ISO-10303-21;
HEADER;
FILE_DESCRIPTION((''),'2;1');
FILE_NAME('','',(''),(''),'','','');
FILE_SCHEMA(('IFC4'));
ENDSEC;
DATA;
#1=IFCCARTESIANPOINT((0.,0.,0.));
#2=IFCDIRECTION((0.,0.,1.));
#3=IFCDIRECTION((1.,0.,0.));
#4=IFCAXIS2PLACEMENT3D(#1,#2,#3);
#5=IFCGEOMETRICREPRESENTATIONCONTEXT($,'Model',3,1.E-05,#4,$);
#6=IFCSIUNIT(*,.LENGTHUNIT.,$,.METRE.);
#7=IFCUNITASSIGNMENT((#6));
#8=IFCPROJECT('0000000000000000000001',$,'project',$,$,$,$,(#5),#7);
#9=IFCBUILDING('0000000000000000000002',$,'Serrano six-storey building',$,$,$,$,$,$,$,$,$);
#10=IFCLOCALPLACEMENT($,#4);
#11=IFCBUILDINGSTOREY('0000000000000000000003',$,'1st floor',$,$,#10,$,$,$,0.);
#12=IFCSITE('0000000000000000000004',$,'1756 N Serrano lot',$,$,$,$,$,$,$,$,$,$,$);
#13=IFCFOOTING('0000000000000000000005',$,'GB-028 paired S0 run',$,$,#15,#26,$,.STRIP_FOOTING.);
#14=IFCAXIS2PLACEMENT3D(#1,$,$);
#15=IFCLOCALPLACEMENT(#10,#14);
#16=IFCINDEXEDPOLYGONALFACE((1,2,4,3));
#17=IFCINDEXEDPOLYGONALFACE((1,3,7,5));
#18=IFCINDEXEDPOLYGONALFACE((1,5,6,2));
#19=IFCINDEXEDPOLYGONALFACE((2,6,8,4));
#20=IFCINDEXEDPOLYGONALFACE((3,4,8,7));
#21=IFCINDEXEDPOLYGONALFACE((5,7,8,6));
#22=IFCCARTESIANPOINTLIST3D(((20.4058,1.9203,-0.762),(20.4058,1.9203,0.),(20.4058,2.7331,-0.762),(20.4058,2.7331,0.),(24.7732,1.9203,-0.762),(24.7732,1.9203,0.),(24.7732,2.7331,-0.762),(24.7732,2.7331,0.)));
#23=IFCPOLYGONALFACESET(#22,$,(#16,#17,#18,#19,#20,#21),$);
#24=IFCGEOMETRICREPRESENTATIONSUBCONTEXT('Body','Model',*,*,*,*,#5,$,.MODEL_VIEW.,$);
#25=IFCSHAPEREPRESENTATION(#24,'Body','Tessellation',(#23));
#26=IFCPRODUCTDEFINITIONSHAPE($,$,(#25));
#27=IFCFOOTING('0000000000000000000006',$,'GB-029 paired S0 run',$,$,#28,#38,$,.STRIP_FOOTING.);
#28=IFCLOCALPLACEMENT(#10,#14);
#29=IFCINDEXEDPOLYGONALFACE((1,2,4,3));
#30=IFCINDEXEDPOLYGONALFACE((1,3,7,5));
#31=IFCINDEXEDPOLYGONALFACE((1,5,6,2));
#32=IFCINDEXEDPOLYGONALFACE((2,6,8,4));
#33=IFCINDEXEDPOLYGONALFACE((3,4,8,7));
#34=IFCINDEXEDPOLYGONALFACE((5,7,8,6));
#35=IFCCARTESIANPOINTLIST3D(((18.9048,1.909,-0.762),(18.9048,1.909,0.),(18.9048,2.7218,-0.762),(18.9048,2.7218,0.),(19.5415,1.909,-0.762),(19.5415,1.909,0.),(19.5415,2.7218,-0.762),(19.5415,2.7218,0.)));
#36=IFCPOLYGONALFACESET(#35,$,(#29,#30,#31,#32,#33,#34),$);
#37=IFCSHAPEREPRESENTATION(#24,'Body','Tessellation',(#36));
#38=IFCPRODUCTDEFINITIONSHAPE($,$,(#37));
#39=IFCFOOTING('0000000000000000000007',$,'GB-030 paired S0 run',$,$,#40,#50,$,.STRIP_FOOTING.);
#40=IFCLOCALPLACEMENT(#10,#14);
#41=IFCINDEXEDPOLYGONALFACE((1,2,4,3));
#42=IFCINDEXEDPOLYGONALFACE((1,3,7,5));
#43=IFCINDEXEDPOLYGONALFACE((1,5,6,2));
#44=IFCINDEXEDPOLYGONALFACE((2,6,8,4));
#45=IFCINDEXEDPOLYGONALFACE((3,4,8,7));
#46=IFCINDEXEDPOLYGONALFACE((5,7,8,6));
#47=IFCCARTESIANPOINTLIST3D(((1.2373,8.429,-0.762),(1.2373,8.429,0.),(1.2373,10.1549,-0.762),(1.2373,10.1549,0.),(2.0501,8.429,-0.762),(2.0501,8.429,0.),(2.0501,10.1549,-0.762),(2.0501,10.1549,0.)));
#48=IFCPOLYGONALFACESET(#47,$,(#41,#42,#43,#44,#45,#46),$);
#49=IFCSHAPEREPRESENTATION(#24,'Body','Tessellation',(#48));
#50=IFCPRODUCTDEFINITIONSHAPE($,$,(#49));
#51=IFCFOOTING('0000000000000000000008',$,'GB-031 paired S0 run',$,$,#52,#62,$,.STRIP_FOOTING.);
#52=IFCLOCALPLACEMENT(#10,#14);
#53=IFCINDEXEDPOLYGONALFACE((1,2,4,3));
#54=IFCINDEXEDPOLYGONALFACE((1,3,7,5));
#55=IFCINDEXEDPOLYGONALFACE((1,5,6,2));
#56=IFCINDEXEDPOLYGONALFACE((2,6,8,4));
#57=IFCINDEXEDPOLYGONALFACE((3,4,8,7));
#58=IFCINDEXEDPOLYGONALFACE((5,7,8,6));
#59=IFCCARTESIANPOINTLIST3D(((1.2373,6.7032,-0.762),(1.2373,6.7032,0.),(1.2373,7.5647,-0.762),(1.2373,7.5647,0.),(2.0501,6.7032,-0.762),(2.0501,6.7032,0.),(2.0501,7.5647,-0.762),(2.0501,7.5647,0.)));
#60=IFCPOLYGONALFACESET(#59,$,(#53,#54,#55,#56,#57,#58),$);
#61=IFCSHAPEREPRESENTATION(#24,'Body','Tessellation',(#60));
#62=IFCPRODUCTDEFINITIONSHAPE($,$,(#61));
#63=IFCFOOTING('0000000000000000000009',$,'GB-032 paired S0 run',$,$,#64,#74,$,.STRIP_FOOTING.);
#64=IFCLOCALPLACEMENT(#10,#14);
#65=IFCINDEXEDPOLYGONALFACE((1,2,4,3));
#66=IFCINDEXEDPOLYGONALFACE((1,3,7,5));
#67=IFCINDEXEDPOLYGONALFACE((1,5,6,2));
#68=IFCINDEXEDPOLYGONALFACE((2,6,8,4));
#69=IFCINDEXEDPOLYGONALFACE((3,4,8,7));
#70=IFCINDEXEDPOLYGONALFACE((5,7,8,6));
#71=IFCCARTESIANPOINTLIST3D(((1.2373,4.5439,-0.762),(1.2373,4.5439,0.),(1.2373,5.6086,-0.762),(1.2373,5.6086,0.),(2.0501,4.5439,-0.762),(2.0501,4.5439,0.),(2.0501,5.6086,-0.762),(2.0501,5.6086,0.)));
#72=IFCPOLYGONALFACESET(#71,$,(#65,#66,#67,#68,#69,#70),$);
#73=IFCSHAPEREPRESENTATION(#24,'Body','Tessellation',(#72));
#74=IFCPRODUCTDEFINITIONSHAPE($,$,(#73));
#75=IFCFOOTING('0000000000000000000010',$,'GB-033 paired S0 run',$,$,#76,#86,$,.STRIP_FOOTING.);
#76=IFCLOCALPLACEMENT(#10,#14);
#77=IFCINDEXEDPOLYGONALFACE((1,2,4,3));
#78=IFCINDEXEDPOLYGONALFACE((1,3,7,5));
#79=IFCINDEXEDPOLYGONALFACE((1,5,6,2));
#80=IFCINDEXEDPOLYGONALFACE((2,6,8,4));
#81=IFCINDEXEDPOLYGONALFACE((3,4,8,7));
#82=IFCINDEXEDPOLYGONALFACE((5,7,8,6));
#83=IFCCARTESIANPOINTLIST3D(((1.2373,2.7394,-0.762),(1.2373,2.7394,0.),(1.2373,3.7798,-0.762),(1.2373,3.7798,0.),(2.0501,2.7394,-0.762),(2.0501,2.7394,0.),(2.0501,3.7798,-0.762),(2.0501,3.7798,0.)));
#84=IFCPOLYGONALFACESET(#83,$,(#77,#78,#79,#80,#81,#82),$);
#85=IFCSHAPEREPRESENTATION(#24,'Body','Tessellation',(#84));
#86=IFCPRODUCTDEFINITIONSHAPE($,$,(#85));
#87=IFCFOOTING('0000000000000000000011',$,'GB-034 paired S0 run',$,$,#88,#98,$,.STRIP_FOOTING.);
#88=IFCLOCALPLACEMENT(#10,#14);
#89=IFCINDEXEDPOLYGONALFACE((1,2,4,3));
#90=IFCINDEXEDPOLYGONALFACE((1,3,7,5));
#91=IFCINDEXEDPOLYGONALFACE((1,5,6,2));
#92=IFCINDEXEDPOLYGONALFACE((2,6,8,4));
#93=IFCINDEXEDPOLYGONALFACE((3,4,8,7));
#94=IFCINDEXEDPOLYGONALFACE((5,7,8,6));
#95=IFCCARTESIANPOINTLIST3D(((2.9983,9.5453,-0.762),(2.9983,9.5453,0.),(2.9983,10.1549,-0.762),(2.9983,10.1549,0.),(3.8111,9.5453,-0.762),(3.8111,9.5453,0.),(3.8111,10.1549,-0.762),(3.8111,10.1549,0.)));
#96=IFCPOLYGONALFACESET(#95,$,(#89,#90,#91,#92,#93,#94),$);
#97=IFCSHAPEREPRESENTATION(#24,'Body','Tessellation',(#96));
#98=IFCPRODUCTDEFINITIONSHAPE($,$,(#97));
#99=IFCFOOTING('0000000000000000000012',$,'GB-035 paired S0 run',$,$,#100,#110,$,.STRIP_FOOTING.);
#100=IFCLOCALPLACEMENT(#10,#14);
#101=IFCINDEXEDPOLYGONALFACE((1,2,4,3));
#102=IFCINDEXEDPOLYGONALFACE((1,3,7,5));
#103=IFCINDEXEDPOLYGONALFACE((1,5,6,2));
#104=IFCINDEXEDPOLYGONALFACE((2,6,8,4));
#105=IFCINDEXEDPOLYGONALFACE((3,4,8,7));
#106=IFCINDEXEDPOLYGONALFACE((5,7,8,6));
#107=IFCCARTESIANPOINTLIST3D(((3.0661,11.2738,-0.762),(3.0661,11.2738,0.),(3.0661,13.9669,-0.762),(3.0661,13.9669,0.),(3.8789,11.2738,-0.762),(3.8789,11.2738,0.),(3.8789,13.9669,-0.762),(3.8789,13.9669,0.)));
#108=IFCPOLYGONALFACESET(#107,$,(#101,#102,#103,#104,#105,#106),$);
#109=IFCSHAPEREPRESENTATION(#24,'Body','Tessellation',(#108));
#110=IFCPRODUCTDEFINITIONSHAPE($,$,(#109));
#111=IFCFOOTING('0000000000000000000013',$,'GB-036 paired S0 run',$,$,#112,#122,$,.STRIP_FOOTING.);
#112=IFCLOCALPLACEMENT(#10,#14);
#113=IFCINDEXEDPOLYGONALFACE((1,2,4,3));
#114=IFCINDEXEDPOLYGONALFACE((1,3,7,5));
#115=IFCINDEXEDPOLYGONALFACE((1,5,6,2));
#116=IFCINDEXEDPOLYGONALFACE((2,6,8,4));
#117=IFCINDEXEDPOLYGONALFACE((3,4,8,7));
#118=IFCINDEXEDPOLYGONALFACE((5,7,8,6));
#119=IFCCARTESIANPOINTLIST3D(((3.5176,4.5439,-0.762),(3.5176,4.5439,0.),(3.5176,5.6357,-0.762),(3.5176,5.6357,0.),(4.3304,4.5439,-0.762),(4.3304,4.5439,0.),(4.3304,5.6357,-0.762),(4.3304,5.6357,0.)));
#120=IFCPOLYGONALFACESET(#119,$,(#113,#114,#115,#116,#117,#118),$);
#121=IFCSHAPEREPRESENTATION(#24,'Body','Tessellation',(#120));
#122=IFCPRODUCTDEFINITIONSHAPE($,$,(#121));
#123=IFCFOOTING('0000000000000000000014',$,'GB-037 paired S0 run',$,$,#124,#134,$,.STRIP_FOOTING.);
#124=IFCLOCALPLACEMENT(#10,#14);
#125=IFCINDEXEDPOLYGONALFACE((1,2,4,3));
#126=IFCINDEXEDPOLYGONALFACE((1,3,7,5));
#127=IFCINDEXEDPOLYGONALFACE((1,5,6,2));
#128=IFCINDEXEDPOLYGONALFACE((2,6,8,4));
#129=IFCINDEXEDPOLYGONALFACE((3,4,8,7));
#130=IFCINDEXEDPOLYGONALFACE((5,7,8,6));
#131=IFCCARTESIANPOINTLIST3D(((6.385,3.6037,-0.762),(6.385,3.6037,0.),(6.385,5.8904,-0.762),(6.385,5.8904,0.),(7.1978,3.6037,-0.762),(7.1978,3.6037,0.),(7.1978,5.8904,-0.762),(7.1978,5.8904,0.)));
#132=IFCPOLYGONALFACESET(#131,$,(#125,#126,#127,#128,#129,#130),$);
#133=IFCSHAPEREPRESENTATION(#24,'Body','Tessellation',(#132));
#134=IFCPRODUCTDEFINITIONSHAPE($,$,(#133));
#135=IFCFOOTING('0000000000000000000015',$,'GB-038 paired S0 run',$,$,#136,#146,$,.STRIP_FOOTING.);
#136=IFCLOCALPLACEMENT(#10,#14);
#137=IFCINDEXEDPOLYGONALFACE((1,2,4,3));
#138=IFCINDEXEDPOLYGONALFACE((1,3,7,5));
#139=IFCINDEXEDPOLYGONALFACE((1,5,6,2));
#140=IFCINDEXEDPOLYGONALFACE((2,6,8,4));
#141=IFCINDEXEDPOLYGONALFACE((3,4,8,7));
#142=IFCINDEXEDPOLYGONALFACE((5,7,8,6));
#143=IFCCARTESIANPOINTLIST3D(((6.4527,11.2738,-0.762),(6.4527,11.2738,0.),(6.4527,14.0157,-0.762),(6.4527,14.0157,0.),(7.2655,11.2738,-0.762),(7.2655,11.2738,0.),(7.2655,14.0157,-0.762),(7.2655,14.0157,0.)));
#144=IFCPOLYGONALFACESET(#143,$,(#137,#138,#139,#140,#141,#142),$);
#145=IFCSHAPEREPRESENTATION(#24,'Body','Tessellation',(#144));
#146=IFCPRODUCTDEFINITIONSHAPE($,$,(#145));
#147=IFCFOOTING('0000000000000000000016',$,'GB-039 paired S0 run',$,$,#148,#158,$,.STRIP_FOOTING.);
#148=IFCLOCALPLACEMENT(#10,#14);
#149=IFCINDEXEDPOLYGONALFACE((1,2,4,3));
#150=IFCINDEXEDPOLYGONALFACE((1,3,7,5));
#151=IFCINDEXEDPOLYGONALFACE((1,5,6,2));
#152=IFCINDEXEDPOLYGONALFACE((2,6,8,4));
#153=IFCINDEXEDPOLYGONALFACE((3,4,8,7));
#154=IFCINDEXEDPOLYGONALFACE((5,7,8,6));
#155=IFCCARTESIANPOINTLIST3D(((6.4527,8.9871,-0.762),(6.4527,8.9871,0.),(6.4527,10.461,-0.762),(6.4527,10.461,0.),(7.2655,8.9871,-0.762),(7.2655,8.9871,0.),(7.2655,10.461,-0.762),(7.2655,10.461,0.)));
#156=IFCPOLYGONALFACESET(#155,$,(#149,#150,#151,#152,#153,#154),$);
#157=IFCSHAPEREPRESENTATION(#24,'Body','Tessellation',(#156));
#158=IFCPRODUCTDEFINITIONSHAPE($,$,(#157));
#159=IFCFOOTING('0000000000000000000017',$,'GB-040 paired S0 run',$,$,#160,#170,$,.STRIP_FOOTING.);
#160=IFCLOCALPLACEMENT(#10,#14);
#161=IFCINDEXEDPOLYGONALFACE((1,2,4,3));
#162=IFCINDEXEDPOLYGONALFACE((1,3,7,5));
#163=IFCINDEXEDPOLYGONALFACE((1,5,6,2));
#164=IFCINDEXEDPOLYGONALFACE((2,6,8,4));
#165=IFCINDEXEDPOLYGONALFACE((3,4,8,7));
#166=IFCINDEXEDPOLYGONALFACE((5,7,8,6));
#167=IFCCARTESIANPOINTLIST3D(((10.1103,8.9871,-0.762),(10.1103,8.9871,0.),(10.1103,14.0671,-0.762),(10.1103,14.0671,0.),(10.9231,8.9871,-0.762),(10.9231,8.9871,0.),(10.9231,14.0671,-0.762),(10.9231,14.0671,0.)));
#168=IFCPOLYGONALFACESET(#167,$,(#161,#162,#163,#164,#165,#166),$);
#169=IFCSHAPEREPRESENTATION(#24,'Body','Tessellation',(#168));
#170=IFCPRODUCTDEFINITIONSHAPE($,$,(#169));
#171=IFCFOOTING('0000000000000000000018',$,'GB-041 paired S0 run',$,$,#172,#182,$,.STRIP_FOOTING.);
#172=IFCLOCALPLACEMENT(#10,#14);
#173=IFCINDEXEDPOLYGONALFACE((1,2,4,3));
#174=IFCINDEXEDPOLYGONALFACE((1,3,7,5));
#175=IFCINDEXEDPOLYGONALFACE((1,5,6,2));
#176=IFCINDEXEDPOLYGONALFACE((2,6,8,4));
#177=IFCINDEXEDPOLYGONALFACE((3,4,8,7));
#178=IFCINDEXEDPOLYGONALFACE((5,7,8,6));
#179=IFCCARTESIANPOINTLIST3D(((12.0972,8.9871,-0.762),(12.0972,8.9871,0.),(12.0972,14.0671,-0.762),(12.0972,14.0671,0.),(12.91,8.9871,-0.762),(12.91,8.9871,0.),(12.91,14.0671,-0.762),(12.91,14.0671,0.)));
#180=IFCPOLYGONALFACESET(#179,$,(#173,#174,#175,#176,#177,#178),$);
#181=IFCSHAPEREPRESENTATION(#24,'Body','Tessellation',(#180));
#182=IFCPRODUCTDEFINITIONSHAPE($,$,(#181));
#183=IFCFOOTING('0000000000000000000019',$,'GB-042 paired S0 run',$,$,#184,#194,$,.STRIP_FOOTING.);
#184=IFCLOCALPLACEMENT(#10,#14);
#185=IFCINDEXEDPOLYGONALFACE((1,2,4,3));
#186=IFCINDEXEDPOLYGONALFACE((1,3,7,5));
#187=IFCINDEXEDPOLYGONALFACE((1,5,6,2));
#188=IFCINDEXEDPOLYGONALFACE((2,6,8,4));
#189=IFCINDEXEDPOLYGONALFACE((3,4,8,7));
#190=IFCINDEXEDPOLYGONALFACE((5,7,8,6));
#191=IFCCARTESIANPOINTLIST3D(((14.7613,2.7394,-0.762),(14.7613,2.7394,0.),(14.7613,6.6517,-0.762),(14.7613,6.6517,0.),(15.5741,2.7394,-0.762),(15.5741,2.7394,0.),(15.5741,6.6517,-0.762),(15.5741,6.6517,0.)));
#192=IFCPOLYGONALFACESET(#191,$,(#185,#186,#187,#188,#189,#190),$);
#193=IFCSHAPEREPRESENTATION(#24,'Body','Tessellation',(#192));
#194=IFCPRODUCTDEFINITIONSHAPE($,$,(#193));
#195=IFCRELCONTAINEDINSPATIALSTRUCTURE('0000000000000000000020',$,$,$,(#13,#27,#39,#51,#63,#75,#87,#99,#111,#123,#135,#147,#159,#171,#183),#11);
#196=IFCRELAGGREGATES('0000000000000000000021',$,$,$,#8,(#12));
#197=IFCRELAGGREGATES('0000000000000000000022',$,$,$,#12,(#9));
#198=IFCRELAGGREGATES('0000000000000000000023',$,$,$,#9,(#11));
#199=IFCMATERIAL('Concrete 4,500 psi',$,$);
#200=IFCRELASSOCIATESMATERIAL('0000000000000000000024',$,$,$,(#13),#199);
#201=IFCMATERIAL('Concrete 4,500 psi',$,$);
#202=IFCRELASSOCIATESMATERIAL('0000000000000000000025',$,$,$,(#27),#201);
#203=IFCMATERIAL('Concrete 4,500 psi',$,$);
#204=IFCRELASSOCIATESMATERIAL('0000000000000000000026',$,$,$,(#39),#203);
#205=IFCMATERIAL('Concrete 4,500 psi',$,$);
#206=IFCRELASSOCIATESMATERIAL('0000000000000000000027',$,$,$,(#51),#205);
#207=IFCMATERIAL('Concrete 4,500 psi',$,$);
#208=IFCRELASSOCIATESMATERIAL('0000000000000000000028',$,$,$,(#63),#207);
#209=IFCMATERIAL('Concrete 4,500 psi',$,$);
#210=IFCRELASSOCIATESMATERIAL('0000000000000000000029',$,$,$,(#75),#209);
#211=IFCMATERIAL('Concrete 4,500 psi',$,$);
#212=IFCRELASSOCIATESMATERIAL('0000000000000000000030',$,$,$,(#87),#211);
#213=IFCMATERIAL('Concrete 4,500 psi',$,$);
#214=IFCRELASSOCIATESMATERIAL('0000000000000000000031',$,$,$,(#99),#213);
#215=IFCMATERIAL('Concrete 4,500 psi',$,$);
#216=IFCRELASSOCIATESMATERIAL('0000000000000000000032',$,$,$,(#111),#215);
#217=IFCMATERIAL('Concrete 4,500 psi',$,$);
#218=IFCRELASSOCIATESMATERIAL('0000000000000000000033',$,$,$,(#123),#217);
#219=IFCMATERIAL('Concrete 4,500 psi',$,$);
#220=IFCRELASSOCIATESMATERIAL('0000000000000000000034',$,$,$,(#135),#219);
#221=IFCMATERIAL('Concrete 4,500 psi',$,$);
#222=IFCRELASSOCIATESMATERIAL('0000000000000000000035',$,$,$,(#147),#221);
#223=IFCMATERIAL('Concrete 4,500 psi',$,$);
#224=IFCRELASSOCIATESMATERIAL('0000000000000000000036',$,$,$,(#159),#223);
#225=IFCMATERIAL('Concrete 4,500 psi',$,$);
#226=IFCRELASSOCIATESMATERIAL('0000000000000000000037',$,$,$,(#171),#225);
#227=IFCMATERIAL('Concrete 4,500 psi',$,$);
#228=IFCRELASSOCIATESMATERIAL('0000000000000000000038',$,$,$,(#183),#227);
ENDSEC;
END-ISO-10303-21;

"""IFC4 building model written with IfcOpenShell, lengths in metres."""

from ifc_helpers import new_model, si_unit, frame, origin_with_axes, place, context, subcontext, project, spatial, polyline, outline, extrude, material, element, save


model = new_model("IFC4")

# Units and contexts
model_context = context("Model", 3, precision=1e-05, world=origin_with_axes())
body_context = subcontext(model_context, "Body", "Model", "MODEL_VIEW")
ifc_project = project(units=[si_unit("LENGTHUNIT", "METRE")], contexts=[model_context])

# Site, building, storey
site = spatial("IfcSite", under=ifc_project, Name="1756 N Serrano lot")
building = spatial("IfcBuilding", under=site, Name="Serrano six-storey building")
storey_placement = place(None, origin_with_axes())
storey = spatial("IfcBuildingStorey", under=building, at=storey_placement, Name="1st floor", Elevation=0.0)

# Footings
ifc_material_1 = material(Name="Concrete 4,500 psi")
footing_1_placement = place(storey_placement, origin_with_axes())
element("IfcFooting", 1, at=footing_1_placement, inside=storey, material=ifc_material_1, Name="GB-028 paired S0 run", PredefinedType="STRIP_FOOTING", context=body_context, shape_type="SweptSolid", body=[
    extrude(outline(polyline([(24.7732, 2.7331), (24.7732, 1.9203), (20.4058, 1.9203), (20.4058, 2.7331), (24.7732, 2.7331)])), frame((0.0, 0.0, -0.762)), (0.0, 0.0, 1.0), 0.762),
])
ifc_material_2 = material(Name="Concrete 4,500 psi")
footing_2_placement = place(storey_placement, origin_with_axes())
element("IfcFooting", 2, at=footing_2_placement, inside=storey, material=ifc_material_2, Name="GB-029 paired S0 run", PredefinedType="STRIP_FOOTING", context=body_context, shape_type="SweptSolid", body=[
    extrude(outline(polyline([(19.5415, 2.7218), (19.5415, 1.909), (18.9048, 1.909), (18.9048, 2.7218), (19.5415, 2.7218)])), frame((0.0, 0.0, -0.762)), (0.0, 0.0, 1.0), 0.762),
])
ifc_material_3 = material(Name="Concrete 4,500 psi")
footing_3_placement = place(storey_placement, origin_with_axes())
element("IfcFooting", 3, at=footing_3_placement, inside=storey, material=ifc_material_3, Name="GB-030 paired S0 run", PredefinedType="STRIP_FOOTING", context=body_context, shape_type="SweptSolid", body=[
    extrude(outline(polyline([(2.0501, 8.429), (1.2373, 8.429), (1.2373, 10.1549), (2.0501, 10.1549), (2.0501, 8.429)])), frame((0.0, 0.0, -0.762)), (0.0, 0.0, 1.0), 0.762),
])
ifc_material_4 = material(Name="Concrete 4,500 psi")
footing_4_placement = place(storey_placement, origin_with_axes())
element("IfcFooting", 4, at=footing_4_placement, inside=storey, material=ifc_material_4, Name="GB-031 paired S0 run", PredefinedType="STRIP_FOOTING", context=body_context, shape_type="SweptSolid", body=[
    extrude(outline(polyline([(2.0501, 6.7032), (1.2373, 6.7032), (1.2373, 7.5647), (2.0501, 7.5647), (2.0501, 6.7032)])), frame((0.0, 0.0, -0.762)), (0.0, 0.0, 1.0), 0.762),
])
ifc_material_5 = material(Name="Concrete 4,500 psi")
footing_5_placement = place(storey_placement, origin_with_axes())
element("IfcFooting", 5, at=footing_5_placement, inside=storey, material=ifc_material_5, Name="GB-032 paired S0 run", PredefinedType="STRIP_FOOTING", context=body_context, shape_type="SweptSolid", body=[
    extrude(outline(polyline([(2.0501, 4.5439), (1.2373, 4.5439), (1.2373, 5.6086), (2.0501, 5.6086), (2.0501, 4.5439)])), frame((0.0, 0.0, -0.762)), (0.0, 0.0, 1.0), 0.762),
])
ifc_material_6 = material(Name="Concrete 4,500 psi")
footing_6_placement = place(storey_placement, origin_with_axes())
element("IfcFooting", 6, at=footing_6_placement, inside=storey, material=ifc_material_6, Name="GB-033 paired S0 run", PredefinedType="STRIP_FOOTING", context=body_context, shape_type="SweptSolid", body=[
    extrude(outline(polyline([(2.0501, 2.7394), (1.2373, 2.7394), (1.2373, 3.7798), (2.0501, 3.7798), (2.0501, 2.7394)])), frame((0.0, 0.0, -0.762)), (0.0, 0.0, 1.0), 0.762),
])
ifc_material_7 = material(Name="Concrete 4,500 psi")
footing_7_placement = place(storey_placement, origin_with_axes())
element("IfcFooting", 7, at=footing_7_placement, inside=storey, material=ifc_material_7, Name="GB-034 paired S0 run", PredefinedType="STRIP_FOOTING", context=body_context, shape_type="SweptSolid", body=[
    extrude(outline(polyline([(3.8111, 9.5453), (2.9983, 9.5453), (2.9983, 10.1549), (3.8111, 10.1549), (3.8111, 9.5453)])), frame((0.0, 0.0, -0.762)), (0.0, 0.0, 1.0), 0.762),
])
ifc_material_8 = material(Name="Concrete 4,500 psi")
footing_8_placement = place(storey_placement, origin_with_axes())
element("IfcFooting", 8, at=footing_8_placement, inside=storey, material=ifc_material_8, Name="GB-035 paired S0 run", PredefinedType="STRIP_FOOTING", context=body_context, shape_type="SweptSolid", body=[
    extrude(outline(polyline([(3.8789, 11.2738), (3.0661, 11.2738), (3.0661, 13.9669), (3.8789, 13.9669), (3.8789, 11.2738)])), frame((0.0, 0.0, -0.762)), (0.0, 0.0, 1.0), 0.762),
])
ifc_material_9 = material(Name="Concrete 4,500 psi")
footing_9_placement = place(storey_placement, origin_with_axes())
element("IfcFooting", 9, at=footing_9_placement, inside=storey, material=ifc_material_9, Name="GB-036 paired S0 run", PredefinedType="STRIP_FOOTING", context=body_context, shape_type="SweptSolid", body=[
    extrude(outline(polyline([(4.3304, 4.5439), (3.5176, 4.5439), (3.5176, 5.6357), (4.3304, 5.6357), (4.3304, 4.5439)])), frame((0.0, 0.0, -0.762)), (0.0, 0.0, 1.0), 0.762),
])
ifc_material_10 = material(Name="Concrete 4,500 psi")
footing_10_placement = place(storey_placement, origin_with_axes())
element("IfcFooting", 10, at=footing_10_placement, inside=storey, material=ifc_material_10, Name="GB-037 paired S0 run", PredefinedType="STRIP_FOOTING", context=body_context, shape_type="SweptSolid", body=[
    extrude(outline(polyline([(7.1978, 3.6037), (6.385, 3.6037), (6.385, 5.8904), (7.1978, 5.8904), (7.1978, 3.6037)])), frame((0.0, 0.0, -0.762)), (0.0, 0.0, 1.0), 0.762),
])
ifc_material_11 = material(Name="Concrete 4,500 psi")
footing_11_placement = place(storey_placement, origin_with_axes())
element("IfcFooting", 11, at=footing_11_placement, inside=storey, material=ifc_material_11, Name="GB-038 paired S0 run", PredefinedType="STRIP_FOOTING", context=body_context, shape_type="SweptSolid", body=[
    extrude(outline(polyline([(7.2655, 11.2738), (6.4527, 11.2738), (6.4527, 14.0157), (7.2655, 14.0157), (7.2655, 11.2738)])), frame((0.0, 0.0, -0.762)), (0.0, 0.0, 1.0), 0.762),
])
ifc_material_12 = material(Name="Concrete 4,500 psi")
footing_12_placement = place(storey_placement, origin_with_axes())
element("IfcFooting", 12, at=footing_12_placement, inside=storey, material=ifc_material_12, Name="GB-039 paired S0 run", PredefinedType="STRIP_FOOTING", context=body_context, shape_type="SweptSolid", body=[
    extrude(outline(polyline([(7.2655, 8.9871), (6.4527, 8.9871), (6.4527, 10.461), (7.2655, 10.461), (7.2655, 8.9871)])), frame((0.0, 0.0, -0.762)), (0.0, 0.0, 1.0), 0.762),
])
ifc_material_13 = material(Name="Concrete 4,500 psi")
footing_13_placement = place(storey_placement, origin_with_axes())
element("IfcFooting", 13, at=footing_13_placement, inside=storey, material=ifc_material_13, Name="GB-040 paired S0 run", PredefinedType="STRIP_FOOTING", context=body_context, shape_type="SweptSolid", body=[
    extrude(outline(polyline([(10.9231, 8.9871), (10.1103, 8.9871), (10.1103, 14.0671), (10.9231, 14.0671), (10.9231, 8.9871)])), frame((0.0, 0.0, -0.762)), (0.0, 0.0, 1.0), 0.762),
])
ifc_material_14 = material(Name="Concrete 4,500 psi")
footing_14_placement = place(storey_placement, origin_with_axes())
element("IfcFooting", 14, at=footing_14_placement, inside=storey, material=ifc_material_14, Name="GB-041 paired S0 run", PredefinedType="STRIP_FOOTING", context=body_context, shape_type="SweptSolid", body=[
    extrude(outline(polyline([(12.91, 8.9871), (12.0972, 8.9871), (12.0972, 14.0671), (12.91, 14.0671), (12.91, 8.9871)])), frame((0.0, 0.0, -0.762)), (0.0, 0.0, 1.0), 0.762),
])
ifc_material_15 = material(Name="Concrete 4,500 psi")
footing_15_placement = place(storey_placement, origin_with_axes())
element("IfcFooting", 15, at=footing_15_placement, inside=storey, material=ifc_material_15, Name="GB-042 paired S0 run", PredefinedType="STRIP_FOOTING", context=body_context, shape_type="SweptSolid", body=[
    extrude(outline(polyline([(15.5741, 2.7394), (14.7613, 2.7394), (14.7613, 6.6517), (15.5741, 6.6517), (15.5741, 2.7394)])), frame((0.0, 0.0, -0.762)), (0.0, 0.0, 1.0), 0.762),
])

save(model, "model.ifc")
